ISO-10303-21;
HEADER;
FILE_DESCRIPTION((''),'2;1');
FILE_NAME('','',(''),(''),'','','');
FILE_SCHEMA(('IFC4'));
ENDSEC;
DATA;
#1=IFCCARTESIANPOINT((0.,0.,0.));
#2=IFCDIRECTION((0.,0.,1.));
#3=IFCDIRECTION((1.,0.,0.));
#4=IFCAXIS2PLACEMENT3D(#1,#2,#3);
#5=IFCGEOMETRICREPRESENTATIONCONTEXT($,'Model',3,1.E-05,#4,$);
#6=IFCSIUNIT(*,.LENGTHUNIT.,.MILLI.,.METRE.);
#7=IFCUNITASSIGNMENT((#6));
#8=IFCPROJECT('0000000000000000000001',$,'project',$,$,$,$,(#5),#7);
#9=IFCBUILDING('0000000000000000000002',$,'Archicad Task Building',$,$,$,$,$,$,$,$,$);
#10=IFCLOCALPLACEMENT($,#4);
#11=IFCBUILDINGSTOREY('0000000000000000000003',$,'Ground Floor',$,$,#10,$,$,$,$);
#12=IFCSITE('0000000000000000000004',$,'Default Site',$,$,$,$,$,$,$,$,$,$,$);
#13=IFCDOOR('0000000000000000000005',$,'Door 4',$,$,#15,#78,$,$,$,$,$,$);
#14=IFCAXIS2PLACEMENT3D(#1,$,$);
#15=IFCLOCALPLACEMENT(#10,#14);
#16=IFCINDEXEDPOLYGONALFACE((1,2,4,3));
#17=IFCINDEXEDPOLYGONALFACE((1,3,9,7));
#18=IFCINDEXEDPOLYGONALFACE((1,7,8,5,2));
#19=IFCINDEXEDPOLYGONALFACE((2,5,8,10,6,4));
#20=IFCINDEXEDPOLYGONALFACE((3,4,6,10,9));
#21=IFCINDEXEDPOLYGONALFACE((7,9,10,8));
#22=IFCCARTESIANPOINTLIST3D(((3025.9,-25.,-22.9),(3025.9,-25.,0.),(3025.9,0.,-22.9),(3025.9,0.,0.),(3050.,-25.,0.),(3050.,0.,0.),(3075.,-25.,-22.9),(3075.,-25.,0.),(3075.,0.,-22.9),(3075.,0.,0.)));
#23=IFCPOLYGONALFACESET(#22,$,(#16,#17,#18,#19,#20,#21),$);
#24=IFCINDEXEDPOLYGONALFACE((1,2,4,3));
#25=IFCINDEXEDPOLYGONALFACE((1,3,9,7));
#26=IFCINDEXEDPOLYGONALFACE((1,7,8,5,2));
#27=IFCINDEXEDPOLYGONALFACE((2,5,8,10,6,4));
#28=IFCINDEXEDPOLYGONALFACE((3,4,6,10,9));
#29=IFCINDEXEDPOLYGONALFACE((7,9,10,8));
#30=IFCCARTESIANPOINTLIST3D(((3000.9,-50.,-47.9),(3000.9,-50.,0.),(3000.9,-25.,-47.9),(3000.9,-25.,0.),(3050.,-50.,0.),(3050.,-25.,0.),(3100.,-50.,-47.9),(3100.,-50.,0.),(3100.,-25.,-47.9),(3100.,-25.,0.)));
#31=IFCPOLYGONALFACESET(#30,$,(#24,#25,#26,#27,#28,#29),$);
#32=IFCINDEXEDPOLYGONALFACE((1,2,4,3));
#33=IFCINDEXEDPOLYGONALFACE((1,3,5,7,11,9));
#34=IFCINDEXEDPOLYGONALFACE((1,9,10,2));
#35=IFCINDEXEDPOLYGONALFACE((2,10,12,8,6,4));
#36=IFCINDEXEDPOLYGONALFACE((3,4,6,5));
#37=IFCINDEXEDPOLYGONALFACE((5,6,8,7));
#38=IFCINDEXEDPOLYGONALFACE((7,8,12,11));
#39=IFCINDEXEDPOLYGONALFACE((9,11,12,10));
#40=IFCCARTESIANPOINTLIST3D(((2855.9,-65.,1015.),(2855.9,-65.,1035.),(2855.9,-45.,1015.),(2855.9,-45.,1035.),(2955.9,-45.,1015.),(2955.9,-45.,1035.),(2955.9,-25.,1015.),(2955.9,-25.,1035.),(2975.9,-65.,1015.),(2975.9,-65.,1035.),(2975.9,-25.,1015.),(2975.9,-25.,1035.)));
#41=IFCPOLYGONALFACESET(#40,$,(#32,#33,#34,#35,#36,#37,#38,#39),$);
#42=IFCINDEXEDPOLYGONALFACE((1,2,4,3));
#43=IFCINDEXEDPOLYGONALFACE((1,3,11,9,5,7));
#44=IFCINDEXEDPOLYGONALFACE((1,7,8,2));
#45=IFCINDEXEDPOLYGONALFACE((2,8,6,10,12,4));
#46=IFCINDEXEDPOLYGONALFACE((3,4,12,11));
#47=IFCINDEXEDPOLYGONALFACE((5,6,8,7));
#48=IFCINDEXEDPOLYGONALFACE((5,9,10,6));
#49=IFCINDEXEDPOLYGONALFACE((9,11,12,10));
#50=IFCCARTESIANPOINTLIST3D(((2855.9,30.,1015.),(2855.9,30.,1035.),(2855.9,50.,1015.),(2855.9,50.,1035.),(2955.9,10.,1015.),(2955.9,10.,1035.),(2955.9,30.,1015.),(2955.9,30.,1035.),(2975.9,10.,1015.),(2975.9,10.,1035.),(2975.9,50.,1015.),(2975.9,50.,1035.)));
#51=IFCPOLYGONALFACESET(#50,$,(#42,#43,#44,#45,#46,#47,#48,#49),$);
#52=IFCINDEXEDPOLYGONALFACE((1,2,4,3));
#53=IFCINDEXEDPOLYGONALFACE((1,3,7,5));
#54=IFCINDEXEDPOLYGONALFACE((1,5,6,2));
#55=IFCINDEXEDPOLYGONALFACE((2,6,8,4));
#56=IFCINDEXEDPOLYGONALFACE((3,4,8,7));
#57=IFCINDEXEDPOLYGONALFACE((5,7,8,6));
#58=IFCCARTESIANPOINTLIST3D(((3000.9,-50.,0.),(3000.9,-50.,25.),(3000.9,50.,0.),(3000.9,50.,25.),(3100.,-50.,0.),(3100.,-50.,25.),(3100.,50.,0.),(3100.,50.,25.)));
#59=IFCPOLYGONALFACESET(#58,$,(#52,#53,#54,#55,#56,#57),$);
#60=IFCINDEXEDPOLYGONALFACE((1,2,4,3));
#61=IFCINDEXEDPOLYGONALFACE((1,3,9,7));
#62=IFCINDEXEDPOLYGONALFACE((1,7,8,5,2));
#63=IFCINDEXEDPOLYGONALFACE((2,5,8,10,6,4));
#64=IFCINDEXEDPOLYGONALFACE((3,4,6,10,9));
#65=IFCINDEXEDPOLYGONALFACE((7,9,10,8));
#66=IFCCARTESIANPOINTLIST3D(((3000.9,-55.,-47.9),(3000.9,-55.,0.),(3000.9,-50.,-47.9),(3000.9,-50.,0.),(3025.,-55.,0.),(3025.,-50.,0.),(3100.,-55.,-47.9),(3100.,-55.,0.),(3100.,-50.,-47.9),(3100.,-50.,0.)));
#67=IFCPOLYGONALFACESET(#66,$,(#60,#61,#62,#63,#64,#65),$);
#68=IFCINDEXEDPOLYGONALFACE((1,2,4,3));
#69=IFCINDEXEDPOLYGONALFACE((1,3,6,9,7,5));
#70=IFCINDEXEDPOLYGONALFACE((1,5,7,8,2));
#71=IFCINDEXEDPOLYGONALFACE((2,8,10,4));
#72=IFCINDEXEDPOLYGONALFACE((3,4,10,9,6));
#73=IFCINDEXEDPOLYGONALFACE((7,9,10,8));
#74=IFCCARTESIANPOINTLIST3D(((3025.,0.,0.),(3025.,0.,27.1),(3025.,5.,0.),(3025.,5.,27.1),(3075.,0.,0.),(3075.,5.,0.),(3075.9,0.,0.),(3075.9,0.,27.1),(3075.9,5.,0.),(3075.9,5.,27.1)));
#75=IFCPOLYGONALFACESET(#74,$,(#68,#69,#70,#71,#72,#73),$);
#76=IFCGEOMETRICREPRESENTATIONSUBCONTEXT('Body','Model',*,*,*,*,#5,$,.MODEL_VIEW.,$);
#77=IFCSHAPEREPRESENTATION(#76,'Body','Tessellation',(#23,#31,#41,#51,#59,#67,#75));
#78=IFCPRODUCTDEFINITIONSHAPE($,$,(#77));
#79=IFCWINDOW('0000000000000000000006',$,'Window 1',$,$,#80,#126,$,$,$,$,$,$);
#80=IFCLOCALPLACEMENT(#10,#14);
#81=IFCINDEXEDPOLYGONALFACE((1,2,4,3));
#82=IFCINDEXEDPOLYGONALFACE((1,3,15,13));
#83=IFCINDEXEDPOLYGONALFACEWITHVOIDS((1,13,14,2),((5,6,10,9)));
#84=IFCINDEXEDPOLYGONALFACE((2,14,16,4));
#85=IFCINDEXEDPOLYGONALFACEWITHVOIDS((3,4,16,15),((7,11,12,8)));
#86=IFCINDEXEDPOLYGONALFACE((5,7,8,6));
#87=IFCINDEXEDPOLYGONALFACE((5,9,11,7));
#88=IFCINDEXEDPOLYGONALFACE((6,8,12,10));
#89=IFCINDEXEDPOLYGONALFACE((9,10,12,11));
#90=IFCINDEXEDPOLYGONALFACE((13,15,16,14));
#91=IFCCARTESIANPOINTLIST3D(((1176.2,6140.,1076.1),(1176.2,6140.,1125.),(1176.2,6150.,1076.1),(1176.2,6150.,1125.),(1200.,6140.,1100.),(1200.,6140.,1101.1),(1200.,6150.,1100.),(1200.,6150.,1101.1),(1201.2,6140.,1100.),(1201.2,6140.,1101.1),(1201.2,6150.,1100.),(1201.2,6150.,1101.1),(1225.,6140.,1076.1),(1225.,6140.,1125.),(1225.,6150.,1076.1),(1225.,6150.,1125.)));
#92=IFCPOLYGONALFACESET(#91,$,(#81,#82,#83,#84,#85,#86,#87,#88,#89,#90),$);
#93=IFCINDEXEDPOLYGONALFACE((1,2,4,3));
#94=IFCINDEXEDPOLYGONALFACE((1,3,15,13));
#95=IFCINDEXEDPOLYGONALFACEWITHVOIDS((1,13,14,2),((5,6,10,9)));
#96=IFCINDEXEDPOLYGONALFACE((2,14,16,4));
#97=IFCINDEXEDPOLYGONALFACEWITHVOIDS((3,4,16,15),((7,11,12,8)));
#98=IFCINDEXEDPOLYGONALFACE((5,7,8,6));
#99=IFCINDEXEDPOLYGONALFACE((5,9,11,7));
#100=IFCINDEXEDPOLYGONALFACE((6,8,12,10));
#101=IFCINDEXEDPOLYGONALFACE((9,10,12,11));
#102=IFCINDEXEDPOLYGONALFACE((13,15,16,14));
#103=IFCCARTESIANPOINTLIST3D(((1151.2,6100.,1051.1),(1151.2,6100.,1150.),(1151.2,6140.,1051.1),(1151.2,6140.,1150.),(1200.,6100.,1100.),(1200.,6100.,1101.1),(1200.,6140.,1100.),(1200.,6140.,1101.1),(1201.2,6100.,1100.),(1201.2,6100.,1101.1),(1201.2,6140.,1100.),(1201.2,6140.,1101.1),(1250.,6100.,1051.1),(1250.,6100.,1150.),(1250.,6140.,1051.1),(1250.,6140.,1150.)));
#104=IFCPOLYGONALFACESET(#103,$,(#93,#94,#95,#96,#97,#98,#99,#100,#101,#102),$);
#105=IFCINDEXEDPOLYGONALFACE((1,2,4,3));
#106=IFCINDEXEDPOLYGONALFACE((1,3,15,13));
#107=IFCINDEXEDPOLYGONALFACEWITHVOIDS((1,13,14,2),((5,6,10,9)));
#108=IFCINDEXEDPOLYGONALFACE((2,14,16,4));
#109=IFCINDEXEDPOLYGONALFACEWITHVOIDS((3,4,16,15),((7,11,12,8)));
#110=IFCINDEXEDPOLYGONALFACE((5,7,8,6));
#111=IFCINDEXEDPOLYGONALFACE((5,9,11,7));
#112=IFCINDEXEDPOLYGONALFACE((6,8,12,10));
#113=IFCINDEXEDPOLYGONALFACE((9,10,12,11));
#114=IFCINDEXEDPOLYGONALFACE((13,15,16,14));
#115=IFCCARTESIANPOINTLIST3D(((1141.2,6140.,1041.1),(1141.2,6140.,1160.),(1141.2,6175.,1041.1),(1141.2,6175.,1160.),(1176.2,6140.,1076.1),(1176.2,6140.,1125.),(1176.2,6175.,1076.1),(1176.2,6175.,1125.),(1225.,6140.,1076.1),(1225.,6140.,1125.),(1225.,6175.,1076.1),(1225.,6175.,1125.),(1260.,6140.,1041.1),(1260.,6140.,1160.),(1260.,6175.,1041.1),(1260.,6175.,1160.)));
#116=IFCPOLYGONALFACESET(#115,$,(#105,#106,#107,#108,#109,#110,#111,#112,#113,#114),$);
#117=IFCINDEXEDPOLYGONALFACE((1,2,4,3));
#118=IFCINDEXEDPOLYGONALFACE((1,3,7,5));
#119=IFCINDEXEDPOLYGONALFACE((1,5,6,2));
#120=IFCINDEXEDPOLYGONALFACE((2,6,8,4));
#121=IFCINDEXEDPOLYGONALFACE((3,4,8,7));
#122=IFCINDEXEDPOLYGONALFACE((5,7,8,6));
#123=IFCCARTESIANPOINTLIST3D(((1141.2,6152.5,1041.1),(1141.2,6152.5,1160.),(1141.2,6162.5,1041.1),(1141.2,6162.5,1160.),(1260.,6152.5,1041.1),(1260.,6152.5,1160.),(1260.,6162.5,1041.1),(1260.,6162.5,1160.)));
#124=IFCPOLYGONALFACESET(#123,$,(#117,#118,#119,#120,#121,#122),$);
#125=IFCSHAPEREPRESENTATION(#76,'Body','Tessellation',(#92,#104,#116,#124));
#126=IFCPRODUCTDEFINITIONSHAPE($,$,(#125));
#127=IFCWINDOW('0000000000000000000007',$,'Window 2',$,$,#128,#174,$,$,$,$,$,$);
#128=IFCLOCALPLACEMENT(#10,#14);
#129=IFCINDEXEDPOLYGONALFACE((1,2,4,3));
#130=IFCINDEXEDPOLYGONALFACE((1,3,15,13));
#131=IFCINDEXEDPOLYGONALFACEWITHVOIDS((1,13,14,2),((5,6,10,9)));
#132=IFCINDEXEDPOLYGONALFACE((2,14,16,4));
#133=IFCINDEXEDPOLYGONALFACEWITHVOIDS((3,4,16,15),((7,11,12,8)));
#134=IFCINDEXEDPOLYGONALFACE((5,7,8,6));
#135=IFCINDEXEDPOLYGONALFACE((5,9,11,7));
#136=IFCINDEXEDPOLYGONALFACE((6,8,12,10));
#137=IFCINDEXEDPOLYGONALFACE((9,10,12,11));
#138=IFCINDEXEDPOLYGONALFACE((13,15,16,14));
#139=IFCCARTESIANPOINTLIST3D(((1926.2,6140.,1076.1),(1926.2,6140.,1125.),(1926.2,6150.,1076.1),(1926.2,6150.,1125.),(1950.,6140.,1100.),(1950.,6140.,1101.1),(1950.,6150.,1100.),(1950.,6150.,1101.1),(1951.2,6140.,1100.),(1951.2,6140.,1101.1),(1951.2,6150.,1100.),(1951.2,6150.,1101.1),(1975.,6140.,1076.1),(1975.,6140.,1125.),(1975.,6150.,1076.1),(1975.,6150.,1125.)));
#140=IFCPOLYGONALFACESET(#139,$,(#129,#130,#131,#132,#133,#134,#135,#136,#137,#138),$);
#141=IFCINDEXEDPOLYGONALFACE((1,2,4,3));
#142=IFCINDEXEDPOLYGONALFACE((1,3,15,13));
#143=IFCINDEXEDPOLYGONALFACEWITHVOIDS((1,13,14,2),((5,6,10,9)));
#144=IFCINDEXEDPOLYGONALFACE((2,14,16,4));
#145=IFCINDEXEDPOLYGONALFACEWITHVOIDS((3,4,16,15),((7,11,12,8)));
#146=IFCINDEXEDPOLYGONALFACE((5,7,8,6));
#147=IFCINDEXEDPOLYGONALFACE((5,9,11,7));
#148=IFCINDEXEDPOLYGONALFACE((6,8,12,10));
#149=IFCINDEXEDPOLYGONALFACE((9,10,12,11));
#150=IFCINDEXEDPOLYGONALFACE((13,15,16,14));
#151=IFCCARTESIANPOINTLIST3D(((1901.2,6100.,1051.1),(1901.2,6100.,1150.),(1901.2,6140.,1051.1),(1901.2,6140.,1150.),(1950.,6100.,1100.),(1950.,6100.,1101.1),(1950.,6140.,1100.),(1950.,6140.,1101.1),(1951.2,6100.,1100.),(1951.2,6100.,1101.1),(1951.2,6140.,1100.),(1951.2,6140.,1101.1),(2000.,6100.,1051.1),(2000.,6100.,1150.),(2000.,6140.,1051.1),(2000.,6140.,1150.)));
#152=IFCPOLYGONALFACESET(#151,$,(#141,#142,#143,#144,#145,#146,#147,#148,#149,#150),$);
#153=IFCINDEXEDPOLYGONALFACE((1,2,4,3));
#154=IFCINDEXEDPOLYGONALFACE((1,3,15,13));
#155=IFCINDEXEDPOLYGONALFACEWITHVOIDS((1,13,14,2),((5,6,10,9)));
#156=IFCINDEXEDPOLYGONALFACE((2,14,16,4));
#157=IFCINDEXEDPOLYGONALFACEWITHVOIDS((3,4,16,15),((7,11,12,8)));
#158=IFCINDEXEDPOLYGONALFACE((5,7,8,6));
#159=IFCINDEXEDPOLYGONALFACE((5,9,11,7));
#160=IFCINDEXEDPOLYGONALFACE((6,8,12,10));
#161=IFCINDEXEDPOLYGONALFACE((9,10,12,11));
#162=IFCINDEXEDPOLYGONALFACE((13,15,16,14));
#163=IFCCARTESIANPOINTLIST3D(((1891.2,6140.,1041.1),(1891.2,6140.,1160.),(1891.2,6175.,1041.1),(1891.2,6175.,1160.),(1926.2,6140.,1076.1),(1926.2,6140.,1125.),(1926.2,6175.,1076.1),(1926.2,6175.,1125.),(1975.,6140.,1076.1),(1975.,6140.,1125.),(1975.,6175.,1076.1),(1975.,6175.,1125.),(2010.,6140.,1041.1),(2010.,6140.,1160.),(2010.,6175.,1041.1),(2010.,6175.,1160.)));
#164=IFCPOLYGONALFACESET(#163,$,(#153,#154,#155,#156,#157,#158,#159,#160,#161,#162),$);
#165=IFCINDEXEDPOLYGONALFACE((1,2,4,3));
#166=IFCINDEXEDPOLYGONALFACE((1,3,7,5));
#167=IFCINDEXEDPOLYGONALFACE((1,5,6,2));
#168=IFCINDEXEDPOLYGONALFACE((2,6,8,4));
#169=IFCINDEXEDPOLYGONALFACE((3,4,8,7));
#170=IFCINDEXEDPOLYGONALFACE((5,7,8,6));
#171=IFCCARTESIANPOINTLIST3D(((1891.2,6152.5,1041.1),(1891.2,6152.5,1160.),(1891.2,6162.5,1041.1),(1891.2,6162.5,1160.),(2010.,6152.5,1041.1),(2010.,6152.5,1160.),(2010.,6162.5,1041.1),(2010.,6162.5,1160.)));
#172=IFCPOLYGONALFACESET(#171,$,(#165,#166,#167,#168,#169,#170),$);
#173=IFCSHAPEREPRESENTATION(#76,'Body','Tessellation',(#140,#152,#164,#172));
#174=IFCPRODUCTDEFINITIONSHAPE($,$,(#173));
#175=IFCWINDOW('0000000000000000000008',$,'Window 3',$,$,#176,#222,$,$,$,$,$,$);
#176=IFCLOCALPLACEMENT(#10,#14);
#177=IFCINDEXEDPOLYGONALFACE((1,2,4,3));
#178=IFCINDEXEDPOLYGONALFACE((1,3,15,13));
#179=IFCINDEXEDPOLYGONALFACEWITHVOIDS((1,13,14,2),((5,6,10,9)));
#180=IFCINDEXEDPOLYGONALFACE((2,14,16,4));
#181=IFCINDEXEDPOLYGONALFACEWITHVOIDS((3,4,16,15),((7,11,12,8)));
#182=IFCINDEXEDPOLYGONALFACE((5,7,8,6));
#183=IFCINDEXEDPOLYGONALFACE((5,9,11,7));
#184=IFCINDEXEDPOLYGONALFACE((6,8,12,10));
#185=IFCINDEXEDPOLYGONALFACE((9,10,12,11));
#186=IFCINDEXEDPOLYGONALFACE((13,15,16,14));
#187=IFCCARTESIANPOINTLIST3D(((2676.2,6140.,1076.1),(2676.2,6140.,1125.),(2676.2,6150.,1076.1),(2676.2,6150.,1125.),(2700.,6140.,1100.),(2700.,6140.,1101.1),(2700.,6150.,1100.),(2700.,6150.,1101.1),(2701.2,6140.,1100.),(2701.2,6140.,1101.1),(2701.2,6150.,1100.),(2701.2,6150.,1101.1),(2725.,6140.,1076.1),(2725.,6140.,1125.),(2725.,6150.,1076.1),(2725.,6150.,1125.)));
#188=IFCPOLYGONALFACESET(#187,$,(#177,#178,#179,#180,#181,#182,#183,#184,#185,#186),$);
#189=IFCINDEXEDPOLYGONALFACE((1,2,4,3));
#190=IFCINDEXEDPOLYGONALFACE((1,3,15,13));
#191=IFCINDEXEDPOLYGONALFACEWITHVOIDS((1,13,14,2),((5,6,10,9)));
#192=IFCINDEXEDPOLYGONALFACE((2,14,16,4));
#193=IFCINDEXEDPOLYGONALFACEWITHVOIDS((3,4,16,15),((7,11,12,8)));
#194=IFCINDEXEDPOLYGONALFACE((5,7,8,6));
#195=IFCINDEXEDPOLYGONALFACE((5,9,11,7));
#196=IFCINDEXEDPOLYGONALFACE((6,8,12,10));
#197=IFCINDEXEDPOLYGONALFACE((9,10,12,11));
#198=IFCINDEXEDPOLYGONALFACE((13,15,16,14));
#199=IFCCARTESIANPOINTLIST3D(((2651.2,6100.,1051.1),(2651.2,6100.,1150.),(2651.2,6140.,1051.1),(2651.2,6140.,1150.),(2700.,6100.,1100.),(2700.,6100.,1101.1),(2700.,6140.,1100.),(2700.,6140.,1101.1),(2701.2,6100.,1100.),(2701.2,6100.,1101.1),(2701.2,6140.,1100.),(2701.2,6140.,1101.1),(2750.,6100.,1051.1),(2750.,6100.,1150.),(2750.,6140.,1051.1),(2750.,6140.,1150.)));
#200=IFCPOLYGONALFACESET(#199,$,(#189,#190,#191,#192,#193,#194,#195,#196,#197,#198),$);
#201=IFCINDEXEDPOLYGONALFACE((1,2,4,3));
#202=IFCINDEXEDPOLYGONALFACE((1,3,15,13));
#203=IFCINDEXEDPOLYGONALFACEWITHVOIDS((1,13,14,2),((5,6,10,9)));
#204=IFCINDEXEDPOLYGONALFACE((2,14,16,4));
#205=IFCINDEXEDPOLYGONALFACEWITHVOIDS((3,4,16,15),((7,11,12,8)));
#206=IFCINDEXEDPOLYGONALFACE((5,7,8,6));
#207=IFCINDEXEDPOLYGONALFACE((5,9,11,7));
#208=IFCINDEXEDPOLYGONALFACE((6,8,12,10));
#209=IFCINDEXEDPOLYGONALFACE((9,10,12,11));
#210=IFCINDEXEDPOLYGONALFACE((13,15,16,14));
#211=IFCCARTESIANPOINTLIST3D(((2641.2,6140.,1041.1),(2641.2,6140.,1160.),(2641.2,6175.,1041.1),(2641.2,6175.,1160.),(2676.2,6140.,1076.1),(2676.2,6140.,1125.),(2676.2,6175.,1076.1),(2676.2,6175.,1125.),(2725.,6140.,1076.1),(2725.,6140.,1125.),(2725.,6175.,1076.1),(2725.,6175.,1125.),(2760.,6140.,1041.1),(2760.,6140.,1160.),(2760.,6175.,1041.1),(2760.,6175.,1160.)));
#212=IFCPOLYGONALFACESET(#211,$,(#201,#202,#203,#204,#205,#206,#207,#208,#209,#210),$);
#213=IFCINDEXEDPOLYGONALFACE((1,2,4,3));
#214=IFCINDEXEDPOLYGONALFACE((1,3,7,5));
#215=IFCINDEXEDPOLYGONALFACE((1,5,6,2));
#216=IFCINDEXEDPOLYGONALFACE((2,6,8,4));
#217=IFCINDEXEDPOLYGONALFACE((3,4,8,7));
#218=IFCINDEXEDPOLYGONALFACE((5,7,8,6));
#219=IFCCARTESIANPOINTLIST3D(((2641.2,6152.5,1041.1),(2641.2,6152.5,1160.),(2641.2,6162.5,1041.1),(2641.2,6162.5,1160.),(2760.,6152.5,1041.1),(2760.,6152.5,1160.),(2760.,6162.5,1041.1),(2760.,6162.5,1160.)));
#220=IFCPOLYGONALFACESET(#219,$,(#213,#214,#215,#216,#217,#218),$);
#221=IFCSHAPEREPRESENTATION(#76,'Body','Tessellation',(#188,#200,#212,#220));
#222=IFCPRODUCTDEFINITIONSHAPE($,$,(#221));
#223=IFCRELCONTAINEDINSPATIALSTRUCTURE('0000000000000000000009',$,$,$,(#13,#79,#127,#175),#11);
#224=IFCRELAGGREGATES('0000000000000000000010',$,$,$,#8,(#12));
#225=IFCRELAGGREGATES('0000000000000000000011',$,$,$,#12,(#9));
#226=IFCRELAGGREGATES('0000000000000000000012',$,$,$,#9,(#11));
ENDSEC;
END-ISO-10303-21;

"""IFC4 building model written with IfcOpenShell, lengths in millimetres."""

from ifc_helpers import new_model, si_unit, frame, origin_with_axes, place, context, subcontext, project, spatial, line, indexed_curve, outline, extrude, element, save


model = new_model("IFC4")

# Units and contexts
model_context = context("Model", 3, precision=1e-05, world=origin_with_axes())
body_context = subcontext(model_context, "Body", "Model", "MODEL_VIEW")
ifc_project = project(units=[si_unit("LENGTHUNIT", "METRE", prefix="MILLI")], contexts=[model_context])

# Site, building, storey
site = spatial("IfcSite", under=ifc_project, Name="Default Site")
building = spatial("IfcBuilding", under=site, Name="Archicad Task Building")
storey_placement = place(None, origin_with_axes())
storey = spatial("IfcBuildingStorey", under=building, at=storey_placement, Name="Ground Floor")

# Door
door_1_placement = place(storey_placement, frame((3050.0, -50.0, 0.0), z_axis=(0.0, 0.0, 1.0), x_axis=(1.0, 0.0, 0.0)))
element("IfcDoor", 1, at=door_1_placement, inside=storey, Name="Door 4", context=body_context, shape_type="SweptSolid", body=[
    extrude(outline(indexed_curve([(0.0, 0.0), (0.0, 2.1), (0.9, 2.1), (0.9, 0.0), (-24.1, 0.0), (-24.1, -22.9), (25.0, -22.9), (25.0, 0.0)], segments=[line(1, 2, 3, 4, 5, 6, 7, 8, 1)])), frame((0.0, 25.0, 0.0), z_axis=(0.0, -1.0, 0.0), x_axis=(1.0, 0.0, 0.0)), (0.0, 0.0, -1.0), 25.0),
    extrude(outline(indexed_curve([(0.0, 0.0), (0.0, 2.1), (0.9, 2.1), (0.9, 0.0), (-49.1, 0.0), (-49.1, -47.9), (50.0, -47.9), (50.0, 0.0)], segments=[line(1, 2, 3, 4, 5, 6, 7, 8, 1)])), frame((0.0, 0.0, 0.0), z_axis=(0.0, -1.0, 0.0), x_axis=(1.0, 0.0, 0.0)), (0.0, 0.0, -1.0), 25.0),
    extrude(outline(indexed_curve([(0.0, 0.0), (-49.1, 0.0), (-49.1, 35.0), (0.0, 35.0)], segments=[line(1, 2, 3, 4, 1)])), frame((25.0, 25.0, 25.0), z_axis=(0.0, 0.0, 1.0), x_axis=(1.0, 0.0, 0.0)), (0.0, 0.0, 1.0), -47.9),
    extrude(outline(indexed_curve([(0.0, 0.0), (0.0, -40.0), (-120.0, -40.0), (-120.0, -20.0), (-20.0, -20.0), (-20.0, 0.0)], segments=[line(1, 2, 3, 4, 5, 6, 1)])), frame((-74.1, 25.0, 1015.0), z_axis=(0.0, 0.0, 1.0), x_axis=(1.0, 0.0, 0.0)), (0.0, 0.0, 1.0), 20.0),
    extrude(outline(indexed_curve([(0.0, 0.0), (0.0, 40.0), (-120.0, 40.0), (-120.0, 20.0), (-20.0, 20.0), (-20.0, 0.0)], segments=[line(1, 2, 3, 4, 5, 6, 1)])), frame((-74.1, 60.0, 1015.0), z_axis=(0.0, 0.0, 1.0), x_axis=(1.0, 0.0, 0.0)), (0.0, 0.0, 1.0), 20.0),
    extrude(outline(indexed_curve([(0.0, 0.0), (-99.1, 0.0), (-99.1, 100.0), (0.0, 100.0)], segments=[line(1, 2, 3, 4, 1)])), frame((50.0, 0.0, 0.0), z_axis=(0.0, 0.0, 1.0), x_axis=(1.0, 0.0, 0.0)), (0.0, 0.0, 1.0), 25.0),
    extrude(outline(indexed_curve([(0.0, 0.0), (0.0, 27.1), (50.9, 27.1), (50.9, 0.0), (-24.1, 0.0), (-24.1, -47.9), (75.0, -47.9), (75.0, 0.0)], segments=[line(1, 2, 3, 4, 5, 6, 7, 8, 1)])), frame((-25.0, -5.0, 0.0), z_axis=(0.0, -1.0, 0.0), x_axis=(1.0, 0.0, 0.0)), (0.0, 0.0, -1.0), 5.0),
    extrude(outline(indexed_curve([(0.0, 0.0), (0.0, 27.1), (50.9, 27.1), (50.9, 0.0), (0.9, 0.0), (0.9, -22.9), (50.0, -22.9), (50.0, 0.0)], segments=[line(1, 2, 3, 4, 5, 6, 7, 8, 1)])), frame((-25.0, 50.0, 0.0), z_axis=(0.0, -1.0, 0.0), x_axis=(1.0, 0.0, 0.0)), (0.0, 0.0, -1.0), 5.0),
])

# Windows
for number, where, z_axis, x_axis, name in (
    (2, (1200.0, 6050.0, 1100.0), (0.0, 0.0, 1.0), (1.0, 0.0, 0.0), "Window 1"),
    (3, (1950.0, 6050.0, 1100.0), (0.0, 0.0, 1.0), (1.0, 0.0, 0.0), "Window 2"),
    (4, (2700.0, 6050.0, 1100.0), (0.0, 0.0, 1.0), (1.0, 0.0, 0.0), "Window 3"),
):
    element("IfcWindow", number, at=place(storey_placement, frame(where, z_axis=z_axis, x_axis=x_axis)), inside=storey, Name=name, context=body_context, shape_type="SweptSolid", body=[
        extrude(outline(indexed_curve([(0.0, 0.0), (1.2, 0.0), (1.2, 1.1), (0.0, 1.1)], segments=[line(1, 2, 3, 4, 1)]), holes=[indexed_curve([(25.0, 25.0), (-23.8, 25.0), (-23.8, -23.9), (25.0, -23.9)], segments=[line(1, 2, 3, 4, 1)])]), frame((0.0, 90.0, 0.0), z_axis=(0.0, -1.0, 0.0), x_axis=(1.0, 0.0, 0.0)), (0.0, 0.0, -1.0), 10.0),
        extrude(outline(indexed_curve([(0.0, 0.0), (1.2, 0.0), (1.2, 1.1), (0.0, 1.1)], segments=[line(1, 2, 3, 4, 1)]), holes=[indexed_curve([(50.0, 50.0), (-48.8, 50.0), (-48.8, -48.9), (50.0, -48.9)], segments=[line(1, 2, 3, 4, 1)])]), frame((0.0, 50.0, 0.0), z_axis=(0.0, -1.0, 0.0), x_axis=(1.0, 0.0, 0.0)), (0.0, 0.0, -1.0), 40.0),
        extrude(outline(indexed_curve([(0.0, 0.0), (-48.8, 0.0), (-48.8, -48.9), (0.0, -48.9)], segments=[line(1, 2, 3, 4, 1)]), holes=[indexed_curve([(35.0, 35.0), (-83.8, 35.0), (-83.8, -83.9), (35.0, -83.9)], segments=[line(1, 2, 3, 4, 1)])]), frame((25.0, 90.0, 25.0), z_axis=(0.0, -1.0, 0.0), x_axis=(1.0, 0.0, 0.0)), (0.0, 0.0, -1.0), 35.0),
        extrude(outline(indexed_curve([(35.0, 35.0), (-83.8, 35.0), (-83.8, -83.9), (35.0, -83.9)], segments=[line(1, 2, 3, 4, 1)])), frame((25.0, 102.5, 25.0), z_axis=(0.0, -1.0, 0.0), x_axis=(1.0, 0.0, 0.0)), (0.0, 0.0, -1.0), 10.0),
    ])

save(model, "model.ifc")
